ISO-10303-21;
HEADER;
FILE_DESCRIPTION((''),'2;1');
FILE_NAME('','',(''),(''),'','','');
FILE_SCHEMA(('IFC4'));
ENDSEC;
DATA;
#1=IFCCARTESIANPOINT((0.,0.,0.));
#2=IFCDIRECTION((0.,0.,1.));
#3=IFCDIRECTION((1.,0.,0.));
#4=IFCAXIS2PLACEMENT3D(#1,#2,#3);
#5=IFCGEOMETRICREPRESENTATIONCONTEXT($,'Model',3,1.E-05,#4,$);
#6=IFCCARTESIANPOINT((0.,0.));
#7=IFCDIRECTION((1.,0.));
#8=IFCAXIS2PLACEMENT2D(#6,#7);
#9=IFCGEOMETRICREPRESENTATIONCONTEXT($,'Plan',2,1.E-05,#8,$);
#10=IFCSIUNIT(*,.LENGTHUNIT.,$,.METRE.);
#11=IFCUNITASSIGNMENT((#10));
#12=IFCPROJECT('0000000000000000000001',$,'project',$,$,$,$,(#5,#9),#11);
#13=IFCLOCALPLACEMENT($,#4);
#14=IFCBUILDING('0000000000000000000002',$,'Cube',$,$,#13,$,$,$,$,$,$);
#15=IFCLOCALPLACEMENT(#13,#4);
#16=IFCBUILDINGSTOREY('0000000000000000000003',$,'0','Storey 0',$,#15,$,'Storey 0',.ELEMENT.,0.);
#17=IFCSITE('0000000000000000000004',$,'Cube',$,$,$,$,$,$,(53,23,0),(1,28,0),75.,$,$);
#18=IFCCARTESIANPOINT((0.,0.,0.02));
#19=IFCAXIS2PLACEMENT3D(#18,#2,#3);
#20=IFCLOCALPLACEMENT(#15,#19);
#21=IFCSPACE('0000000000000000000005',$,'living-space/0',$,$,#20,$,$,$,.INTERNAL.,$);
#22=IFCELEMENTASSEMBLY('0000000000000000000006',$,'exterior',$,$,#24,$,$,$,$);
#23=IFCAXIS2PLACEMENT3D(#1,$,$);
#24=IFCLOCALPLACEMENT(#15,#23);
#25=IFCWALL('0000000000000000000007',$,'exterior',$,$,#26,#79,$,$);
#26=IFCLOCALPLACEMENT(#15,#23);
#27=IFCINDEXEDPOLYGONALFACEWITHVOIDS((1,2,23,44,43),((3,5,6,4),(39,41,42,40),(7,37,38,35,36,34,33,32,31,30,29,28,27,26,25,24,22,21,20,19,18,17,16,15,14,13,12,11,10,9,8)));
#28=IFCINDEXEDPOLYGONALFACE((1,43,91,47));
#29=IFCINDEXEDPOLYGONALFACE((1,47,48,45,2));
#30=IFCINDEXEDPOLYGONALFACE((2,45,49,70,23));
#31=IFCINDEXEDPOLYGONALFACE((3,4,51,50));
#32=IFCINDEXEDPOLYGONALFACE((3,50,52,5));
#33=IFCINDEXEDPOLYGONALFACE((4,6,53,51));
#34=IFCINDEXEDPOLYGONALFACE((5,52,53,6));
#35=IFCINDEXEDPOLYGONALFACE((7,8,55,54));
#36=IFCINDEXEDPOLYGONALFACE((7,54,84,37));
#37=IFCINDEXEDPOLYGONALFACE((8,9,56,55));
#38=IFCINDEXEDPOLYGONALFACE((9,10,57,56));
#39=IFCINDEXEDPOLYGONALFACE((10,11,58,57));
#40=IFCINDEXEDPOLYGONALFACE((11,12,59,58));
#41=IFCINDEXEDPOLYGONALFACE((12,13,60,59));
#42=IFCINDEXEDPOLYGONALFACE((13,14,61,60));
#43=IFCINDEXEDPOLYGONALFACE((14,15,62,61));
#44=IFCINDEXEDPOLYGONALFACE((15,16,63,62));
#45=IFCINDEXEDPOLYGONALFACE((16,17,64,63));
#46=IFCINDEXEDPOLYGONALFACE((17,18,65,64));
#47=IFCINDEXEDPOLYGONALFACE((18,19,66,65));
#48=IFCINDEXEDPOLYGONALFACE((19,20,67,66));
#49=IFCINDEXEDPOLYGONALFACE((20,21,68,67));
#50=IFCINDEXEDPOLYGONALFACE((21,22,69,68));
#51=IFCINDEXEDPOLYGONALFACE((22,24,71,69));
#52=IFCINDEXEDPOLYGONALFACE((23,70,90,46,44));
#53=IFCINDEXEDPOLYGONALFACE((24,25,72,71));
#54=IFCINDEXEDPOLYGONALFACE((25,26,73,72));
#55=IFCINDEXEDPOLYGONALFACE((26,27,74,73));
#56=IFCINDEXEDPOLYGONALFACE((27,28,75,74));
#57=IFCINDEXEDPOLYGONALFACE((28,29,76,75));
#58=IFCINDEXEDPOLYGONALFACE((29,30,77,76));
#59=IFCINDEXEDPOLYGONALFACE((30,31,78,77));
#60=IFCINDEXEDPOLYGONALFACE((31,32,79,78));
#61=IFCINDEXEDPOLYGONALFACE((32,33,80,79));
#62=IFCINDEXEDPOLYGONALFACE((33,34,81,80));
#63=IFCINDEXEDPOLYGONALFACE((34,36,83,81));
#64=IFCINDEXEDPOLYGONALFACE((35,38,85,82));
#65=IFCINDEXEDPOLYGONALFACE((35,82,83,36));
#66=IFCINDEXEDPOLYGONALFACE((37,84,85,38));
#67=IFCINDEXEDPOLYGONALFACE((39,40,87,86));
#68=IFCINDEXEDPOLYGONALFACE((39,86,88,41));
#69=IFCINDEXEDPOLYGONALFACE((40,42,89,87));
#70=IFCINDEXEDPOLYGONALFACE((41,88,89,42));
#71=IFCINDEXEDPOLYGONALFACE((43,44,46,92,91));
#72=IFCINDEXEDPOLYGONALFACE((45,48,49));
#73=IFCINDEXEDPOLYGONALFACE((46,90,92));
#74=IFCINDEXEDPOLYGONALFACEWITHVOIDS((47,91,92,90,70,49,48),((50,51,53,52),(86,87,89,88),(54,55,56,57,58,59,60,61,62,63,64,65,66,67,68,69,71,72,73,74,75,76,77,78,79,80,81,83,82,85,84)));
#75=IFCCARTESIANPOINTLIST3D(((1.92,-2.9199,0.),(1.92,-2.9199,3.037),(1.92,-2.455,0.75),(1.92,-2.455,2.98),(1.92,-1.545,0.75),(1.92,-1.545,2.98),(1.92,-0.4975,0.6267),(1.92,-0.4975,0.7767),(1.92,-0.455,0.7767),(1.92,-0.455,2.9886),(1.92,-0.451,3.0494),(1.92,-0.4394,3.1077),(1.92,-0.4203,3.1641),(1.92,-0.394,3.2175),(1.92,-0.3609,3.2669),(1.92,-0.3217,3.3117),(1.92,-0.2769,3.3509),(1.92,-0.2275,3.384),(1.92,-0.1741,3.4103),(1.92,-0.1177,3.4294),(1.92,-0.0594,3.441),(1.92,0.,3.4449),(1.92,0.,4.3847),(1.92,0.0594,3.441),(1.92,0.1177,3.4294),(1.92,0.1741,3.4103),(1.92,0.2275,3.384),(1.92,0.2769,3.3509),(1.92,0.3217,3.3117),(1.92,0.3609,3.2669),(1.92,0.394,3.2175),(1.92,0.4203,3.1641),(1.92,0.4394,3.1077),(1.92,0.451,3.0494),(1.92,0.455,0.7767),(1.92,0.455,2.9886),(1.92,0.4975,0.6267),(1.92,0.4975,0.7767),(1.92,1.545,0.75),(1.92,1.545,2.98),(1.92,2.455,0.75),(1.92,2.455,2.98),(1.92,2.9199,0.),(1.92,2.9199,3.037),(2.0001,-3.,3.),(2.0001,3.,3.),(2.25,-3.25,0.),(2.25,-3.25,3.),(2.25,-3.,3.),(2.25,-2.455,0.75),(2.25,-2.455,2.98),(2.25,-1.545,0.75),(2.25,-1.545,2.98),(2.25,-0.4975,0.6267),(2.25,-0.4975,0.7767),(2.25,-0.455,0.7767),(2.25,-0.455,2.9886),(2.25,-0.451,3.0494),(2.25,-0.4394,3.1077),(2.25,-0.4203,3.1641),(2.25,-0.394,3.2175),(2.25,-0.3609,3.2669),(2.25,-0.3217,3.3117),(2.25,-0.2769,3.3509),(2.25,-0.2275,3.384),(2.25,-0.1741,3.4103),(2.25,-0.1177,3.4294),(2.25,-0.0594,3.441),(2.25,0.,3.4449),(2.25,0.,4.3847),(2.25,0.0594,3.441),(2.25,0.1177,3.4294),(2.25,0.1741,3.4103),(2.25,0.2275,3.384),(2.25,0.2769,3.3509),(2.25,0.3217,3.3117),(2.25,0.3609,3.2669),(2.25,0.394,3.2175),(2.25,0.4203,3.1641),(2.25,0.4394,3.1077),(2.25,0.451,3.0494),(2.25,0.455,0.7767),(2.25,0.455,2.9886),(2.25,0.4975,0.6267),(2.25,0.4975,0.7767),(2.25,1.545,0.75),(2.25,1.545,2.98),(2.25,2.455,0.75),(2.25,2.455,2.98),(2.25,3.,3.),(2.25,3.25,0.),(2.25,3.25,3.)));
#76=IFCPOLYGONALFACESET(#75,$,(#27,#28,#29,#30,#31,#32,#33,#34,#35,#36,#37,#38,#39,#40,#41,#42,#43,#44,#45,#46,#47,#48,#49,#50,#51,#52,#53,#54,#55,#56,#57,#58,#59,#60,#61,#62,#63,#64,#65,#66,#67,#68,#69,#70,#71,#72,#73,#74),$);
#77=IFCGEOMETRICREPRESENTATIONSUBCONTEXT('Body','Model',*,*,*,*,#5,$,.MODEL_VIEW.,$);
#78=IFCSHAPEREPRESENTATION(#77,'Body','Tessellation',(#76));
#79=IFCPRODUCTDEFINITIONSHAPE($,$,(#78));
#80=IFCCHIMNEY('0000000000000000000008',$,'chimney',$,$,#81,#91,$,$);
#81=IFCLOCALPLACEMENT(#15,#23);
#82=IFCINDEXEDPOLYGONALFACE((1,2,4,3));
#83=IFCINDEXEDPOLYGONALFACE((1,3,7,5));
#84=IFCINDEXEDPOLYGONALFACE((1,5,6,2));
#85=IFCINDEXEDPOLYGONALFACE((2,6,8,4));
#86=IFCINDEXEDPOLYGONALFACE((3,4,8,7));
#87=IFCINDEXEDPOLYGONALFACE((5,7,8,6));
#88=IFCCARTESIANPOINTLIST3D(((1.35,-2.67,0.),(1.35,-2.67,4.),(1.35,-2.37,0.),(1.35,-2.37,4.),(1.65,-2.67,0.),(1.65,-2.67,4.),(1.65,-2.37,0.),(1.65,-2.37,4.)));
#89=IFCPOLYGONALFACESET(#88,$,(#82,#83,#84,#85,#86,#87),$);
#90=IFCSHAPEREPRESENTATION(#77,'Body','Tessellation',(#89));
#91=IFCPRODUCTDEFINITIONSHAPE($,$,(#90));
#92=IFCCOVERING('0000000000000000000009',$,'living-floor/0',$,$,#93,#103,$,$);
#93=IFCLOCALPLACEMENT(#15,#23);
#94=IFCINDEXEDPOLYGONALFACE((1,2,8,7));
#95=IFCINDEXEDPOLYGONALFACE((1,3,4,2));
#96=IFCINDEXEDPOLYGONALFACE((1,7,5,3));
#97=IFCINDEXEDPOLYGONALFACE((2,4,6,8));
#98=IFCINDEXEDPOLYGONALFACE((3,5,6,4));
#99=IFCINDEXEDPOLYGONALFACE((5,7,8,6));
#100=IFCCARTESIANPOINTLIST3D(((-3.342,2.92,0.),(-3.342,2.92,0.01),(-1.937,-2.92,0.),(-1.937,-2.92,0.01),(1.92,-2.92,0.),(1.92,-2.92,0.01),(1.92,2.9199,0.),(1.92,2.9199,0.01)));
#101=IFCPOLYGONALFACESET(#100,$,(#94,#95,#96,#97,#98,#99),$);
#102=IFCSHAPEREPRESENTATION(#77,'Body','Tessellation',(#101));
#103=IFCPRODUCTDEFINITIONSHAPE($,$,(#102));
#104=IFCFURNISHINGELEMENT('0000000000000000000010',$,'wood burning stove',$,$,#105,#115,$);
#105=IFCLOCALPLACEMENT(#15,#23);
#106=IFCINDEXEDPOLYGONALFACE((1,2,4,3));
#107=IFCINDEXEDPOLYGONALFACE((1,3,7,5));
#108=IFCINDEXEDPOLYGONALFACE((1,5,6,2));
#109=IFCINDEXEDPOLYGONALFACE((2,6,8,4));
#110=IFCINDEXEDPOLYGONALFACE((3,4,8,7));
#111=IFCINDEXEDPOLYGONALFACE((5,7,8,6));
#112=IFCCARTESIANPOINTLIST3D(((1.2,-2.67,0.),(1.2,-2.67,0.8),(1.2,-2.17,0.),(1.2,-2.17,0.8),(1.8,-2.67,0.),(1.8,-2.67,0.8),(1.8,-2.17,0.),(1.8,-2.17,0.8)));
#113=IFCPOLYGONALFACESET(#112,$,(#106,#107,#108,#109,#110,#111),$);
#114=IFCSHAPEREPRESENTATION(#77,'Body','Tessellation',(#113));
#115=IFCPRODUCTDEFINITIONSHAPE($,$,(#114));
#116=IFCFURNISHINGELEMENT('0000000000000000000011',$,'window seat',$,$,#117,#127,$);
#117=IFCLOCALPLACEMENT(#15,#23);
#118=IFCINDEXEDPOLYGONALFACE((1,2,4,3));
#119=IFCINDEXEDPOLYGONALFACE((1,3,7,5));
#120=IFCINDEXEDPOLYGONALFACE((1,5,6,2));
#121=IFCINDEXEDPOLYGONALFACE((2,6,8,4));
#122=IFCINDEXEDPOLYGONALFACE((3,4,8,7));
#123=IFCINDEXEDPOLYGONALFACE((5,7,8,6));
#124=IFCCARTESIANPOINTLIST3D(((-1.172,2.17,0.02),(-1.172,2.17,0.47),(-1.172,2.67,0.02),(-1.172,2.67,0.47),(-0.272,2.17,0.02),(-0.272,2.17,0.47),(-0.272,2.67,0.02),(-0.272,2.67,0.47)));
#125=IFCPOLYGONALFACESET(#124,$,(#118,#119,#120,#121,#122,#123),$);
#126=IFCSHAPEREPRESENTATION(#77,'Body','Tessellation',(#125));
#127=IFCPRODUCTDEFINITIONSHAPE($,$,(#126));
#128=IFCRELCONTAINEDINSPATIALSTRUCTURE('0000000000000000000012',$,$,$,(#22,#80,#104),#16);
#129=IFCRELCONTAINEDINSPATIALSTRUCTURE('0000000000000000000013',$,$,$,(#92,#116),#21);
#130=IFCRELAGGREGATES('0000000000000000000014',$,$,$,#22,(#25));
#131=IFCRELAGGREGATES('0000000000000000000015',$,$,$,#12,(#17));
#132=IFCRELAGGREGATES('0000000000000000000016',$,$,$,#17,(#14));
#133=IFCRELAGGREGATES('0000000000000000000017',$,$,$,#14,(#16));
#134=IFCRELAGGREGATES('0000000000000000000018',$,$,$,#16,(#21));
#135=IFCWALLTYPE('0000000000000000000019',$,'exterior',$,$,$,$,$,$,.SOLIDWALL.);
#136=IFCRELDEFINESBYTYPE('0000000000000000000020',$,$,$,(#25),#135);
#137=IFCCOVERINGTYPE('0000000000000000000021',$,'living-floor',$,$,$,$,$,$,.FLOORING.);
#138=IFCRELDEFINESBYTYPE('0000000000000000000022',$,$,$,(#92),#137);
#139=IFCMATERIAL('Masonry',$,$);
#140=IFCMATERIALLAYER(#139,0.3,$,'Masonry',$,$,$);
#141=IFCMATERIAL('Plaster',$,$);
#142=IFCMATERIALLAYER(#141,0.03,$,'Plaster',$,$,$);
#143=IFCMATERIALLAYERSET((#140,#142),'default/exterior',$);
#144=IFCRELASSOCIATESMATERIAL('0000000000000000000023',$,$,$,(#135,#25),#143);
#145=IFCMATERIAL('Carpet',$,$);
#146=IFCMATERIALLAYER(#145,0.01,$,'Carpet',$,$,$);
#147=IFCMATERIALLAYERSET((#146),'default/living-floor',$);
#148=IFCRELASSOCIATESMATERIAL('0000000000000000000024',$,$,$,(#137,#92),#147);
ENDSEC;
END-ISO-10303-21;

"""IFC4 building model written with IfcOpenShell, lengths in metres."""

from ifc_helpers import new_model, si_unit, frame, origin, origin_with_axes, origin_2d_with_axis, place, context, subcontext, project, spatial, polyline, indexed_curve, outline, extrude, clip, bounded_halfspace, material, layer, layer_set, layer_usage, type_object, element, aggregate, save


model = new_model("IFC4")

# Units and contexts
model_context = context("Model", 3, precision=1e-05, world=origin_with_axes())
plan_context = context("Plan", 2, precision=1e-05, world=origin_2d_with_axis())
body_context = subcontext(model_context, "Body", "Model", "MODEL_VIEW")
ifc_project = project(units=[si_unit("LENGTHUNIT", "METRE")], contexts=[model_context, plan_context])

# Site, building, storey
site = spatial("IfcSite", under=ifc_project, Name="Cube", RefLatitude=(53, 23, 0), RefLongitude=(1, 28, 0), RefElevation=75.0)
building_placement = place(None, origin_with_axes())
building = spatial("IfcBuilding", under=site, at=building_placement, Name="Cube")
storey_placement = place(building_placement, origin_with_axes())
storey = spatial("IfcBuildingStorey", under=building, at=storey_placement, Name="0", Description="Storey 0", LongName="Storey 0", CompositionType="ELEMENT", Elevation=0.0)

# Element assembly, wall, openings
ifc_material_1 = material(Name="Masonry")
ifc_layer_1 = layer(ifc_material_1, 0.3, Name="Masonry")
ifc_material_2 = material(Name="Plaster")
ifc_layer_2 = layer(ifc_material_2, 0.03, Name="Plaster")
ifc_layer_set_1 = layer_set([ifc_layer_1, ifc_layer_2], Name="default/exterior")
wall_type = type_object("IfcWallType", Name="exterior", PredefinedType="SOLIDWALL", material=ifc_layer_set_1)
assembly_1_placement = place(storey_placement, frame((2.0, -3.0, 0.0), z_axis=(0.0, 0.0, 1.0), x_axis=(0.0, 1.0, 0.0)))
assembly_1 = element("IfcElementAssembly", 1, at=assembly_1_placement, inside=storey, Name="exterior")
ifc_layer_usage_1 = layer_usage(ifc_layer_set_1, "AXIS2", "POSITIVE", -0.25)
wall_1_placement = place(assembly_1_placement, origin_with_axes())
wall_1 = element("IfcWall", 2, at=wall_1_placement, type_object=wall_type, material=ifc_layer_usage_1, Name="exterior", context=body_context, shape_type="Clipping", body=[
    clip(clip(clip(clip(extrude(outline(polyline([(0.0801, 0.08), (-0.25, -0.25), (6.25, -0.25), (5.9199, 0.08), (0.0801, 0.08)])), origin(), (0.0, 0.0, 1.0), 4.385), bounded_halfspace(frame((6.0, 0.0, 3.0), z_axis=(0.419069, 0.0, 0.907954), x_axis=(0.0, -1.0, 0.0)), False, origin(), polyline([(6.0, -1.0), (3.0, -1.0), (3.0, 1.0), (6.0, 1.0), (6.0, -1.0)]))), bounded_halfspace(frame((6.0, 0.0, 3.0), z_axis=(0.0, 0.0, 1.0), x_axis=(0.0, 1.0, 0.0)), False, origin(), polyline([(6.0, 1.0), (7.0, 1.0), (7.0, -1.0), (6.0, -1.0), (6.0, 1.0)]))), bounded_halfspace(frame((3.0, 0.0, 4.3847), z_axis=(-0.419069, 0.0, 0.907954), x_axis=(0.0, -1.0, 0.0)), False, origin(), polyline([(3.0, -1.0), (0.0, -1.0), (0.0, 1.0), (3.0, 1.0), (3.0, -1.0)]))), bounded_halfspace(frame((0.0, 0.0, 3.0), z_axis=(0.0, 0.0, 1.0), x_axis=(0.0, -1.0, 0.0)), False, origin(), polyline([(0.0, -1.0), (-1.0, -1.0), (-1.0, 1.0), (0.0, 1.0), (0.0, -1.0)]))),
])
opening_1_placement = place(wall_1_placement, frame((0.545, -0.25, 0.75), z_axis=(0.0, 0.0, 1.0), x_axis=(1.0, 0.0, 0.0)))
element("IfcOpeningElement", 3, at=opening_1_placement, cuts=wall_1, PredefinedType="OPENING", context=body_context, shape_type="SweptSolid", body=[
    extrude(outline(polyline([(0.0, -0.02), (0.91, -0.02), (0.91, 0.35), (0.0, 0.35), (0.0, -0.02)])), origin(), (0.0, 0.0, 1.0), 2.23),
])
opening_2_placement = place(wall_1_placement, frame((2.545, -0.25, 0.75), z_axis=(0.0, 0.0, 1.0), x_axis=(1.0, 0.0, 0.0)))
element("IfcOpeningElement", 4, at=opening_2_placement, cuts=wall_1, PredefinedType="OPENING", context=body_context, shape_type="SweptSolid", body=[
    extrude(outline(polyline([(0.1333, 2.5617), (0.1781, 2.6009), (0.2275, 2.634), (0.2809, 2.6603), (0.3373, 2.6794), (0.3956, 2.691), (0.455, 2.6949), (0.5144, 2.691), (0.5727, 2.6794), (0.6291, 2.6603), (0.6825, 2.634), (0.7319, 2.6009), (0.7767, 2.5617), (0.8159, 2.5169), (0.849, 2.4675), (0.8753, 2.4141), (0.8944, 2.3577), (0.906, 2.2994), (0.91, 2.2386), (0.91, 2.2069), (0.91, 0.0267), (0.9525, 0.0267), (0.9525, -0.1233), (-0.0425, -0.1233), (-0.0425, 0.0267), (0.0, 0.0267), (0.0, 2.2069), (0.0, 2.2386), (0.004, 2.2994), (0.0156, 2.3577), (0.0347, 2.4141), (0.061, 2.4675), (0.0941, 2.5169), (0.1333, 2.5617)])), frame((0.0, -0.02, 0.0), z_axis=(0.0, -1.0, 0.0), x_axis=(1.0, 0.0, 0.0)), (0.0, 0.0, -1.0), 0.37),
])
opening_3_placement = place(wall_1_placement, frame((4.545, -0.25, 0.75), z_axis=(0.0, 0.0, 1.0), x_axis=(1.0, 0.0, 0.0)))
element("IfcOpeningElement", 5, at=opening_3_placement, cuts=wall_1, PredefinedType="OPENING", context=body_context, shape_type="SweptSolid", body=[
    extrude(outline(polyline([(0.0, -0.02), (0.91, -0.02), (0.91, 0.35), (0.0, 0.35), (0.0, -0.02)])), origin(), (0.0, 0.0, 1.0), 2.23),
])
aggregate(assembly_1, [wall_1])

# Chimney
chimney_placement = place(storey_placement, frame((1.35, -2.67, 0.0), z_axis=(0.0, 0.0, 1.0), x_axis=(1.0, 0.0, 0.0)))
element("IfcChimney", 6, at=chimney_placement, inside=storey, Name="chimney", context=body_context, shape_type="SweptSolid", body=[
    extrude(outline(indexed_curve([(0.0, 0.0), (0.3, 0.0), (0.3, 0.3), (0.0, 0.3)])), None, (0.0, 0.0, 1.0), 4.0),
])

# Shared definitions
space_placement = place(storey_placement, frame((0.0, 0.0, 0.02), z_axis=(0.0, 0.0, 1.0), x_axis=(1.0, 0.0, 0.0)))
space = spatial("IfcSpace", under=storey, at=space_placement, Name="living-space/0", PredefinedType="INTERNAL")

# Covering
ifc_material_3 = material(Name="Carpet")
ifc_layer_3 = layer(ifc_material_3, 0.01, Name="Carpet")
ifc_layer_set_2 = layer_set([ifc_layer_3], Name="default/living-floor")
ifc_layer_usage_2 = layer_usage(ifc_layer_set_2, "AXIS3", "POSITIVE", 0.0)
covering_type = type_object("IfcCoveringType", Name="living-floor", PredefinedType="FLOORING", material=ifc_layer_set_2)
covering_placement = place(space_placement, frame((0.0, 0.0, -0.02), z_axis=(0.0, 0.0, 1.0), x_axis=(1.0, 0.0, 0.0)))
element("IfcCovering", 7, at=covering_placement, inside=space, type_object=covering_type, material=ifc_layer_usage_2, Name="living-floor/0", context=body_context, shape_type="SweptSolid", body=[
    extrude(outline(polyline([(1.92, 2.9199), (-3.342, 2.92), (-1.937, -2.92), (1.92, -2.92), (1.92, 2.9199)])), origin_with_axes(), (0.0, 0.0, 1.0), 0.01),
])

# Furnishing elements
furnishing_1_placement = place(storey_placement, frame((1.2, -2.67, 0.0), z_axis=(0.0, 0.0, 1.0), x_axis=(1.0, 0.0, 0.0)))
element("IfcFurnishingElement", 8, at=furnishing_1_placement, inside=storey, Name="wood burning stove", context=body_context, shape_type="SweptSolid", body=[
    extrude(outline(indexed_curve([(0.0, 0.0), (0.6, 0.0), (0.6, 0.5), (0.0, 0.5)])), None, (0.0, 0.0, 1.0), 0.8),
])
furnishing_2_placement = place(space_placement, frame((-1.172, 2.17, 0.0), z_axis=(0.0, 0.0, 1.0), x_axis=(1.0, 0.0, 0.0)))
element("IfcFurnishingElement", 9, at=furnishing_2_placement, inside=space, Name="window seat", context=body_context, shape_type="SweptSolid", body=[
    extrude(outline(indexed_curve([(0.0, 0.0), (0.9, 0.0), (0.9, 0.5), (0.0, 0.5)])), None, (0.0, 0.0, 1.0), 0.45),
])

save(model, "model.ifc")
